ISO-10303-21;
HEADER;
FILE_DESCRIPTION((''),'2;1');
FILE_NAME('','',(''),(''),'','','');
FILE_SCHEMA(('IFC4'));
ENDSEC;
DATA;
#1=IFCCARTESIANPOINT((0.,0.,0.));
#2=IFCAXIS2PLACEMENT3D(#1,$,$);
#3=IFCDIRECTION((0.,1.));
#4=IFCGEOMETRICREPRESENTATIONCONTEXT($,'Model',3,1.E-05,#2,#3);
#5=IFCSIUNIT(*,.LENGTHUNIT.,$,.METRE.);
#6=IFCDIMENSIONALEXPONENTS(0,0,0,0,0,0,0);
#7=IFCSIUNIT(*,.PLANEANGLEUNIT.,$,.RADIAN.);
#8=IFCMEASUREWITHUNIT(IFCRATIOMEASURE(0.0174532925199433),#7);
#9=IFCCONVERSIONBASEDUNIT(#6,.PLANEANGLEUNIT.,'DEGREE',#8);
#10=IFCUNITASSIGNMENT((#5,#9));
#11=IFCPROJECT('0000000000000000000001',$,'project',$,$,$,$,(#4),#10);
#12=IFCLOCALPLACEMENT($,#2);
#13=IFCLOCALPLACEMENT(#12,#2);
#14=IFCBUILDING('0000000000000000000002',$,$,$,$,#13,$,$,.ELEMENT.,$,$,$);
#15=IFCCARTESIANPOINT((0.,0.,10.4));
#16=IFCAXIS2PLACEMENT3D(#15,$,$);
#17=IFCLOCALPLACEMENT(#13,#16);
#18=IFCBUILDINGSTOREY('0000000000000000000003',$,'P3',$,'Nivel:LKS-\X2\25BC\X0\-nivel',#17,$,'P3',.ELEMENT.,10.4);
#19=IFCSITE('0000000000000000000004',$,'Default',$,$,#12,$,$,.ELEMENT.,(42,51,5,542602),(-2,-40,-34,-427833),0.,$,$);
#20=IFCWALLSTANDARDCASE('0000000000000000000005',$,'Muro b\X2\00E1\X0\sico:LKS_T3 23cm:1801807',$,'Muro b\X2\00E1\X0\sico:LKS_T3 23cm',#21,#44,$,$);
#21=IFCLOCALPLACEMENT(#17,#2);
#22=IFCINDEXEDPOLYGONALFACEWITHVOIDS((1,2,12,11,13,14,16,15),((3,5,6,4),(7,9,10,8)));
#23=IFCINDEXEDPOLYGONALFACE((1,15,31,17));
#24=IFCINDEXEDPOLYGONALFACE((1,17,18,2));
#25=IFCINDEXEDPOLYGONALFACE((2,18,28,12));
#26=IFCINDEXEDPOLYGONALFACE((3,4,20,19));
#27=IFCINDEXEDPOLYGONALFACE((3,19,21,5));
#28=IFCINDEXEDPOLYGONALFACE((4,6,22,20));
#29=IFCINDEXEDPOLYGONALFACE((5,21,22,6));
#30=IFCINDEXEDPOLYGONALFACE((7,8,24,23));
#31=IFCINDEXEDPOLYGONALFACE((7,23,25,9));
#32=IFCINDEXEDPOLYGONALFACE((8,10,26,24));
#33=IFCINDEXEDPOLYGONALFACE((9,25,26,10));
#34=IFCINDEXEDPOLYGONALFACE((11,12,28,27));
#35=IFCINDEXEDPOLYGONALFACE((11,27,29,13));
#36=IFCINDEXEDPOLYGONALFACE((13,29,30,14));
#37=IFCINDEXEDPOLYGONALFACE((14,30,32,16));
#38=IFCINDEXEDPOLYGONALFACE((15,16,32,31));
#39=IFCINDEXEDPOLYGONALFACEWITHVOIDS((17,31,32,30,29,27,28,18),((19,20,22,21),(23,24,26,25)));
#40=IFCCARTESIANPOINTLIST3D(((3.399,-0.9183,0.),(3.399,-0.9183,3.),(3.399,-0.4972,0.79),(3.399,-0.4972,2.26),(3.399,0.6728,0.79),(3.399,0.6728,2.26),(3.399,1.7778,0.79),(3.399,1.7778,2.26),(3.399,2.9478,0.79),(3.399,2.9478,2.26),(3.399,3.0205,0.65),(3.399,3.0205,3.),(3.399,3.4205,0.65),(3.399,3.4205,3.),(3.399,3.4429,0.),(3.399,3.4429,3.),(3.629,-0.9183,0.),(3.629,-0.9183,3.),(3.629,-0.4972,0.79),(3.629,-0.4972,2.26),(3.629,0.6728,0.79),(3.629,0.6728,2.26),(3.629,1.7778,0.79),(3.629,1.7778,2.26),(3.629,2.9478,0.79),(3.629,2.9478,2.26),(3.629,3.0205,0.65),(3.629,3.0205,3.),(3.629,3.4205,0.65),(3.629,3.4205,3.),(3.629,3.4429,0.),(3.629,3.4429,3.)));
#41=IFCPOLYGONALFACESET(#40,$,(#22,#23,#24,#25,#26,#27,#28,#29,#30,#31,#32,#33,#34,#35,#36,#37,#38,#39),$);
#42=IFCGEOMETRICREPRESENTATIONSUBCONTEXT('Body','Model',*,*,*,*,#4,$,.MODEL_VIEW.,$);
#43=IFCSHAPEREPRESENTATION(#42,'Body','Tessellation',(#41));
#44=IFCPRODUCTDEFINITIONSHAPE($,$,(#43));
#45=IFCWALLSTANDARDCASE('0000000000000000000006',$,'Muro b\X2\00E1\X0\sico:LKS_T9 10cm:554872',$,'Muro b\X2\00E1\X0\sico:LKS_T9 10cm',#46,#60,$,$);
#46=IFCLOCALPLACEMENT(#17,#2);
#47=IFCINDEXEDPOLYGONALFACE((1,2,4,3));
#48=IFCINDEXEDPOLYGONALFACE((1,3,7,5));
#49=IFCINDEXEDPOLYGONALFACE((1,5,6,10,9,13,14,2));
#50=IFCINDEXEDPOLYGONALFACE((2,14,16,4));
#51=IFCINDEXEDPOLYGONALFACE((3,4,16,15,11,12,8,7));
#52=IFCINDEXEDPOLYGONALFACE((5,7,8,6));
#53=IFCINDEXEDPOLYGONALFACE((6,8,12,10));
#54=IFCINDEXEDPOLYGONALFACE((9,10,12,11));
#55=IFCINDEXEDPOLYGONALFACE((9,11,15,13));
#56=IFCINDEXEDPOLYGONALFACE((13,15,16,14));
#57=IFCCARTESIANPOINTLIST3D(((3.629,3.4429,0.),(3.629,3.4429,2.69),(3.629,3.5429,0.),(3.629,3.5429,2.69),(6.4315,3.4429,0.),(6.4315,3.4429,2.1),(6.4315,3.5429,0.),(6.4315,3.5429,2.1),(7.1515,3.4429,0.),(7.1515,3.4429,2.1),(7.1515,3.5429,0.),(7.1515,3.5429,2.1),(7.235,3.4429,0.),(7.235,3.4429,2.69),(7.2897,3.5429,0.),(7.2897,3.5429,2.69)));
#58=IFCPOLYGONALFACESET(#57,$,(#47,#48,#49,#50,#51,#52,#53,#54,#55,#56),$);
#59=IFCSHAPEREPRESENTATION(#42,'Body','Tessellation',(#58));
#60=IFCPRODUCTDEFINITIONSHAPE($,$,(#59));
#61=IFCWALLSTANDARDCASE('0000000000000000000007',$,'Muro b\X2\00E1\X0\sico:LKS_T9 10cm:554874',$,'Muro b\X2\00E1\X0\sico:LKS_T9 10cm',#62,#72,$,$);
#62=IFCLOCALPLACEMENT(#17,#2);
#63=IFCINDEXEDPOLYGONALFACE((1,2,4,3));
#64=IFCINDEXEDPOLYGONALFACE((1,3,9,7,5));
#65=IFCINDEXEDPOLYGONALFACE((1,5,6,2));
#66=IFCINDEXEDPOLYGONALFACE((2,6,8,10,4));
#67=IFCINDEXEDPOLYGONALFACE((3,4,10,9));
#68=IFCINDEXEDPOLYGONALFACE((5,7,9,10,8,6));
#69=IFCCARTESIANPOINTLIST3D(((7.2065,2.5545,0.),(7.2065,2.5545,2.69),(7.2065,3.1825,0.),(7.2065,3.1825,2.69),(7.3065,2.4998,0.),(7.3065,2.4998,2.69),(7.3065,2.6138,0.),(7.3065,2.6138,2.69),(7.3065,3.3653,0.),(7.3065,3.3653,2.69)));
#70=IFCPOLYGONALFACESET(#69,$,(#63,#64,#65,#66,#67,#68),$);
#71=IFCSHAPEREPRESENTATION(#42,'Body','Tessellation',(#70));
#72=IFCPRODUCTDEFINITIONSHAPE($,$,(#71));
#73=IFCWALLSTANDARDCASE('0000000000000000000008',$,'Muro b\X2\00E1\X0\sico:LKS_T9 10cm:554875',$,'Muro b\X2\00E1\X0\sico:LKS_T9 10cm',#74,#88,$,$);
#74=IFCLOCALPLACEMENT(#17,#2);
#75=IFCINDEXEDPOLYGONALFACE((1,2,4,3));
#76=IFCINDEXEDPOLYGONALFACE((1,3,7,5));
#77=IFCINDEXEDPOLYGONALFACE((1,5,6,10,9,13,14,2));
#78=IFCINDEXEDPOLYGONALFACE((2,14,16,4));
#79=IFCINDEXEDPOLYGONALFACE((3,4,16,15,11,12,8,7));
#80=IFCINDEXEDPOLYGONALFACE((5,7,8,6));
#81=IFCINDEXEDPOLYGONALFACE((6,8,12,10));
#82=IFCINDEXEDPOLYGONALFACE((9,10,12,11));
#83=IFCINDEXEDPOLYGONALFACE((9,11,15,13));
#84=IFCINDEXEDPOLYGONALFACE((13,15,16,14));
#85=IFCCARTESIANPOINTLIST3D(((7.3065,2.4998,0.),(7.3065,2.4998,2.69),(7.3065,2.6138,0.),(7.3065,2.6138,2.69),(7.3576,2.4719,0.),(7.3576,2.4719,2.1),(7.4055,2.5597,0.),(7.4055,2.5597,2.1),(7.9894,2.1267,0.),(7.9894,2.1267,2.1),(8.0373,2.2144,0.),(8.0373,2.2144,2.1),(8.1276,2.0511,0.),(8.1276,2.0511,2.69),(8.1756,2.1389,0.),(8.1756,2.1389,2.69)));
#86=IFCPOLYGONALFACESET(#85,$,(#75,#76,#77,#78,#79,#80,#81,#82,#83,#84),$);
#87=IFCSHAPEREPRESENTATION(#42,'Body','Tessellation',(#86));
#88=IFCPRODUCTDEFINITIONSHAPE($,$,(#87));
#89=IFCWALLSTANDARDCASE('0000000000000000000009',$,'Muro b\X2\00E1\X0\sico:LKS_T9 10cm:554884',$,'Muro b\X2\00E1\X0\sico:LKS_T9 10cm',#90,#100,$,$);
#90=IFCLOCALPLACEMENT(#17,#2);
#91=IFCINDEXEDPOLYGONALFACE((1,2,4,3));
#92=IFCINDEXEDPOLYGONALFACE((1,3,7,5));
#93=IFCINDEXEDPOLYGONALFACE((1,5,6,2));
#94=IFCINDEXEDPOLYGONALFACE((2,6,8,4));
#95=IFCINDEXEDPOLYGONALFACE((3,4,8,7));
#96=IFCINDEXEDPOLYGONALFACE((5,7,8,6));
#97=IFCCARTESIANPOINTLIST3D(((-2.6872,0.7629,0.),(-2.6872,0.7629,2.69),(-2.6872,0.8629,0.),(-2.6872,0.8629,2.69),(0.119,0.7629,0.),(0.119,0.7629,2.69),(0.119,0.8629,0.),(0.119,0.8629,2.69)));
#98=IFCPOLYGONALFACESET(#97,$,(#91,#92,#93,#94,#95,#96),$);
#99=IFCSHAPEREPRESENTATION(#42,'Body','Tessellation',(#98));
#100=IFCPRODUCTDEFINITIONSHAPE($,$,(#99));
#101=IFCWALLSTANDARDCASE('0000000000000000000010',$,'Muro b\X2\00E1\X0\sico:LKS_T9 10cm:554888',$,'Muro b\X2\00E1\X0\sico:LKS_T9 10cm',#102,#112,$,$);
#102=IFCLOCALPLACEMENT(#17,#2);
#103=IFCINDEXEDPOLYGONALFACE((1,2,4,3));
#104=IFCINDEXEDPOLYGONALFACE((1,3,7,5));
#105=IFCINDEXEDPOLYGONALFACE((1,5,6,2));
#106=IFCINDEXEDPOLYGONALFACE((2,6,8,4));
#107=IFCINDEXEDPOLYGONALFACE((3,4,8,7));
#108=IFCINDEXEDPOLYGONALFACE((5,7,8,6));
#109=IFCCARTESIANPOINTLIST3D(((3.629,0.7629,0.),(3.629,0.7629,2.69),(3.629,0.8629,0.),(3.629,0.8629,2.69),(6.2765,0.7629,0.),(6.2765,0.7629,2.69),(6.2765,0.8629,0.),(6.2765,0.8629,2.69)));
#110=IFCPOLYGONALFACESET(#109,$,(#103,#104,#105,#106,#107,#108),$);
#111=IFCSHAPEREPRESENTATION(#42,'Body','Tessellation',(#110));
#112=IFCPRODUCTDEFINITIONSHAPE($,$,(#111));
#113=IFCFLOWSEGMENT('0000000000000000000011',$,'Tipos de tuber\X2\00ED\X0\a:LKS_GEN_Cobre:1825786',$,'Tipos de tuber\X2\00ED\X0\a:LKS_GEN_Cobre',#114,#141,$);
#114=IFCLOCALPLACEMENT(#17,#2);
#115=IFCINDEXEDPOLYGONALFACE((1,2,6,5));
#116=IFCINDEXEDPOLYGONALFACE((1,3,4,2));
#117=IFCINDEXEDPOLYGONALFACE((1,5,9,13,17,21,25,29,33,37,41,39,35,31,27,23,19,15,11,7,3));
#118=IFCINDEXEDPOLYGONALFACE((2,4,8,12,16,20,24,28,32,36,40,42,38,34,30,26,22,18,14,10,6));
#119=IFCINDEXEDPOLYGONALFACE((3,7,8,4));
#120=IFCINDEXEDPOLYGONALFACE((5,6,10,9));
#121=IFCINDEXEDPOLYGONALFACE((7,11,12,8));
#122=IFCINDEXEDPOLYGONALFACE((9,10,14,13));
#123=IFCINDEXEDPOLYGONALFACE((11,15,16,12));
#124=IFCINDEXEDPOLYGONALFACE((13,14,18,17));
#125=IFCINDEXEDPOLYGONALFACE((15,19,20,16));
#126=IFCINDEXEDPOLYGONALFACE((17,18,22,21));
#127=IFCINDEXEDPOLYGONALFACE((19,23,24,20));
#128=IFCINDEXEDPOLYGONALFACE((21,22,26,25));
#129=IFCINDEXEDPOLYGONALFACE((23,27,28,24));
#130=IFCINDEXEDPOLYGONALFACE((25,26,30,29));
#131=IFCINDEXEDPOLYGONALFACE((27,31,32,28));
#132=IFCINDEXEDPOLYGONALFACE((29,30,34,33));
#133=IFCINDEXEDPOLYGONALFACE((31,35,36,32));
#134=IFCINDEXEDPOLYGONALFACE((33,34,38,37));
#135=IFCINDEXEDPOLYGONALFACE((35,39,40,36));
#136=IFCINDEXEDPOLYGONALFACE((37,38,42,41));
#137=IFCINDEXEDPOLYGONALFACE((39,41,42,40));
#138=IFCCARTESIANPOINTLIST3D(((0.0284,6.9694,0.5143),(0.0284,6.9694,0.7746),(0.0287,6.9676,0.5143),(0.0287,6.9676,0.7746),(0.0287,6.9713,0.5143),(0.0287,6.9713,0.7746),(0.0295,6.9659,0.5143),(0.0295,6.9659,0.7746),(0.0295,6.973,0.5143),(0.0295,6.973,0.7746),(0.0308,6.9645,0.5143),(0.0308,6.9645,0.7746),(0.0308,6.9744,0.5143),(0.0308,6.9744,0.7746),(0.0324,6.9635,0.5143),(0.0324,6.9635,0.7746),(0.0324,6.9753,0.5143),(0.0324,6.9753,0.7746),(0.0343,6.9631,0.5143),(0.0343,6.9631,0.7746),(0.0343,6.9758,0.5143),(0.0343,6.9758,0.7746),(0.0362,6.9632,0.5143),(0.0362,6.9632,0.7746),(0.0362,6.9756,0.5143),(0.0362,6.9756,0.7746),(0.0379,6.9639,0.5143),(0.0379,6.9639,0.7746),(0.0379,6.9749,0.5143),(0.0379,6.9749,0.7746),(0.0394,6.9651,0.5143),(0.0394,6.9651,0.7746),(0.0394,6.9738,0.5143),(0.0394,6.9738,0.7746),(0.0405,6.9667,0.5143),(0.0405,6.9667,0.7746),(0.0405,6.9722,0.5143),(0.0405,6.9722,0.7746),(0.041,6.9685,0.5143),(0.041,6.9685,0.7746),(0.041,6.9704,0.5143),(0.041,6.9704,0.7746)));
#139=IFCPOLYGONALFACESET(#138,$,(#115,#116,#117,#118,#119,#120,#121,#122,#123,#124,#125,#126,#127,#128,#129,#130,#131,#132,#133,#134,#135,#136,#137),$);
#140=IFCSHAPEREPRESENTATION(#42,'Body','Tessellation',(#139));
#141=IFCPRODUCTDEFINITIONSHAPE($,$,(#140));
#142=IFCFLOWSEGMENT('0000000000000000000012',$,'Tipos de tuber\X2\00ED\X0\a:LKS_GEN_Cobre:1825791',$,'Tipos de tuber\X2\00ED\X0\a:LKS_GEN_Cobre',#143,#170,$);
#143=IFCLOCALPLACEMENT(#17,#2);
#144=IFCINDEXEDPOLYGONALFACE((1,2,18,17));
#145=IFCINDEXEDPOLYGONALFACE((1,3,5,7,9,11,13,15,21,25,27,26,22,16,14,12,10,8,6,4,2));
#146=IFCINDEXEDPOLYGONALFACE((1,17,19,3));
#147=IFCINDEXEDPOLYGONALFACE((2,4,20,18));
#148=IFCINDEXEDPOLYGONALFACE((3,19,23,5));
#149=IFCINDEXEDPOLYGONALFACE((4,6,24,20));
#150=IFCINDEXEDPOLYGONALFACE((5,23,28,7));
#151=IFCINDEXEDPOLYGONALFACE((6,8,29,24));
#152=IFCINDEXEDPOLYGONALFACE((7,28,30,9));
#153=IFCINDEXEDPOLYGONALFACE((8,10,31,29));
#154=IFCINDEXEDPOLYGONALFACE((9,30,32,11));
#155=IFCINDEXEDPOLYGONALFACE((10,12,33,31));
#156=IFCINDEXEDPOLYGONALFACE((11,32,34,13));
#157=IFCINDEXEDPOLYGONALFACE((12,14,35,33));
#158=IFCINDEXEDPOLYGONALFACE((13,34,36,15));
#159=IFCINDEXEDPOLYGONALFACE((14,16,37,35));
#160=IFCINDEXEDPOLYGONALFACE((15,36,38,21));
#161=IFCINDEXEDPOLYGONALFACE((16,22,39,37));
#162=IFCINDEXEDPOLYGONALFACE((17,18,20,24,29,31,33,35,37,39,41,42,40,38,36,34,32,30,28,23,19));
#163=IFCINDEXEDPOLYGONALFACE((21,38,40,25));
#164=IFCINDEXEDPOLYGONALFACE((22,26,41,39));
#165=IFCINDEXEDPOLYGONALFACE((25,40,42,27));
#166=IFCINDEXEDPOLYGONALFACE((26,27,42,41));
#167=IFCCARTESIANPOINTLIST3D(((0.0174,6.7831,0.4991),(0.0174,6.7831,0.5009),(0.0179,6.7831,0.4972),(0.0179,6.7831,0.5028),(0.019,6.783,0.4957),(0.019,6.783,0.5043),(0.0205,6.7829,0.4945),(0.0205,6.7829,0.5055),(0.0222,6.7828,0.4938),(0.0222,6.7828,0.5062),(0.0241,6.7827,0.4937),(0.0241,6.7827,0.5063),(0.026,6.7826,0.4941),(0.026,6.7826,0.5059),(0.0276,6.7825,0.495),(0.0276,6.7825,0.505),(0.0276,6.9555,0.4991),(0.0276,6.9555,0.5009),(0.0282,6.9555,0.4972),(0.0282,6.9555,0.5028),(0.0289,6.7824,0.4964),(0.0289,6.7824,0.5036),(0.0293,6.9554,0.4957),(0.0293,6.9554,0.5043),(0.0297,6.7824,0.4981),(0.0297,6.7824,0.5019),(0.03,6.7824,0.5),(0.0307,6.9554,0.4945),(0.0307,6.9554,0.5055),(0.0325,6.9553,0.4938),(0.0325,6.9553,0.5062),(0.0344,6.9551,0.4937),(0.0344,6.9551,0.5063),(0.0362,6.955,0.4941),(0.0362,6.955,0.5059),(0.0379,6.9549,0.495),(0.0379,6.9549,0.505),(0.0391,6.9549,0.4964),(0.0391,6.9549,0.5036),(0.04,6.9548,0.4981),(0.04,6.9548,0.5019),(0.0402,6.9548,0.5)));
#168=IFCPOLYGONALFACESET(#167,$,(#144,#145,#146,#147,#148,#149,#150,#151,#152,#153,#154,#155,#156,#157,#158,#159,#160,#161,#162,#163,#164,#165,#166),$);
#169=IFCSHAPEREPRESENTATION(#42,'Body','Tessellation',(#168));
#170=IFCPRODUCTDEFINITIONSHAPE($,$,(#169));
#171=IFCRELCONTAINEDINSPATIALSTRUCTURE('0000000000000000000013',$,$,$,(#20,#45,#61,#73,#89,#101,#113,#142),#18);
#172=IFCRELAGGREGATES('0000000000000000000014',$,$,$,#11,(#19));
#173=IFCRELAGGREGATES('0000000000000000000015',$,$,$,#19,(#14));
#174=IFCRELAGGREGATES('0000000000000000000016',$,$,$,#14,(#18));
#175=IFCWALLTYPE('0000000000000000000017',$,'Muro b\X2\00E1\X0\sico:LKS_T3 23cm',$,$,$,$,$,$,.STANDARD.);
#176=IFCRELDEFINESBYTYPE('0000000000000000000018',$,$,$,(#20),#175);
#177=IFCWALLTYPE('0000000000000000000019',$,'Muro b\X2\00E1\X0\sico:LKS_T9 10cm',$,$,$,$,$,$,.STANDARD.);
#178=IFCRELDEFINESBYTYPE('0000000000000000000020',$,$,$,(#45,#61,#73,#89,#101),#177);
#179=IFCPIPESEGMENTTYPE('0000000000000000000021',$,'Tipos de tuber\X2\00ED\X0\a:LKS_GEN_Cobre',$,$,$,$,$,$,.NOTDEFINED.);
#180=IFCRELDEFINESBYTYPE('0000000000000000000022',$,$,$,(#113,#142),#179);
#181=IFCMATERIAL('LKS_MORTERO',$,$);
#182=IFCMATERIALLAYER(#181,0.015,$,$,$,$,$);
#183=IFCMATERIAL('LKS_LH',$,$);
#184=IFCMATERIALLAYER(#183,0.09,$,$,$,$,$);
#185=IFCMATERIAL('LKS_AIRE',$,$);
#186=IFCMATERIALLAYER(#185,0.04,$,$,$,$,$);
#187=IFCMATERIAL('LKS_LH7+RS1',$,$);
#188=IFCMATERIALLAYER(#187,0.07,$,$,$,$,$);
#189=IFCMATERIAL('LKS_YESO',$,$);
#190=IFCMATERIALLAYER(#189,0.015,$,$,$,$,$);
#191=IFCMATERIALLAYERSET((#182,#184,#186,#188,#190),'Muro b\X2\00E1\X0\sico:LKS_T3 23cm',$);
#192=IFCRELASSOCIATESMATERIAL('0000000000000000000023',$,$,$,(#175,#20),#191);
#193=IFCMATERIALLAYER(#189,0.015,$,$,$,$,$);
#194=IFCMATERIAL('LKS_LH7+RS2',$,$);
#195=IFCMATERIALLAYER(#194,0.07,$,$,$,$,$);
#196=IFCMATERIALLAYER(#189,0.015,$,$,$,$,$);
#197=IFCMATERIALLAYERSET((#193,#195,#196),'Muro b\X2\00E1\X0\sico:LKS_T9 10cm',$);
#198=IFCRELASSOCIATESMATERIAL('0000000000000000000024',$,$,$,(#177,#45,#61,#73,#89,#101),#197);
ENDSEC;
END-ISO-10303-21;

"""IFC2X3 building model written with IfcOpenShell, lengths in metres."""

from ifc_helpers import new_model, entity, si_unit, converted_unit, direction, frame, frame_2d, origin, place, context, subcontext, project, spatial, polyline, rectangle, circle, outline, extrude, clip, bounded_halfspace, material, layer, layer_set, layer_usage, type_object, element, save


model = new_model("IFC2X3")

# Units and contexts
model_context = context("Model", 3, precision=1e-05, world=origin(), true_north=direction((0.0, 1.0)))
body_context = subcontext(model_context, "Body", "Model", "MODEL_VIEW")
ifc_project = project(units=[si_unit("LENGTHUNIT", "METRE"), converted_unit("PLANEANGLEUNIT", "DEGREE", entity("IfcRatioMeasure", 0.0174532925199433), si_unit("PLANEANGLEUNIT", "RADIAN"), dimensions=[0, 0, 0, 0, 0, 0, 0])], contexts=[model_context])

# Site, building, storey
site_placement = place(None, origin())
site = spatial("IfcSite", under=ifc_project, at=site_placement, Name="Default", CompositionType="ELEMENT", RefLatitude=(42, 51, 5, 542602), RefLongitude=(-2, -40, -34, -427833), RefElevation=0.0)
building_placement = place(site_placement, origin())
building = spatial("IfcBuilding", under=site, at=building_placement, CompositionType="ELEMENT")
storey_placement = place(building_placement, frame((0.0, 0.0, 10.4)))
storey = spatial("IfcBuildingStorey", under=building, at=storey_placement, Name="P3", ObjectType="Nivel:LKS-▼-nivel", LongName="P3", CompositionType="ELEMENT", Elevation=10.4)

# Shared definitions
ifc_material_1 = material(Name="LKS_MORTERO")

# Wall, openings
ifc_layer_1 = layer(ifc_material_1, 0.015)
ifc_material_2 = material(Name="LKS_LH")
ifc_layer_2 = layer(ifc_material_2, 0.09)
ifc_material_3 = material(Name="LKS_AIRE")
ifc_layer_3 = layer(ifc_material_3, 0.04)
ifc_material_4 = material(Name="LKS_LH7+RS1")
ifc_layer_4 = layer(ifc_material_4, 0.07)
ifc_material_5 = material(Name="LKS_YESO")
ifc_layer_5 = layer(ifc_material_5, 0.015)
ifc_layer_set_1 = layer_set([ifc_layer_1, ifc_layer_2, ifc_layer_3, ifc_layer_4, ifc_layer_5], Name="Muro básico:LKS_T3 23cm")
ifc_layer_usage_1 = layer_usage(ifc_layer_set_1, "AXIS2", "POSITIVE", -0.115)
wall_type_1 = type_object("IfcWallType", Name="Muro básico:LKS_T3 23cm", PredefinedType="STANDARD", material=ifc_layer_set_1)
wall_1_placement = place(storey_placement, frame((3.514, 3.4429, 0.0), z_axis=(0.0, 0.0, 1.0), x_axis=(0.0, -1.0, 0.0)))
wall_1 = element("IfcWallStandardCase", 1, at=wall_1_placement, inside=storey, type_object=wall_type_1, material=ifc_layer_usage_1, Name="Muro básico:LKS_T3 23cm:1801807", ObjectType="Muro básico:LKS_T3 23cm", context=body_context, shape_type="Clipping", body=[
    clip(extrude(rectangle(XDim=4.3611, YDim=0.23, at=frame_2d((2.1806, 0.0), x_axis=(-1.0, 0.0))), origin(), (0.0, 0.0, 1.0), 3.0), bounded_halfspace(frame((0.4224, -0.115, 0.65), z_axis=(0.0, 0.0, -1.0), x_axis=(0.0, -1.0, 0.0)), True, frame((0.4224, -0.115, 0.65), z_axis=(0.0, 0.0, -1.0), x_axis=(0.0, -1.0, 0.0)), polyline([(0.0, 0.0), (0.0, 0.4), (-0.23, 0.4), (-0.23, 0.0), (0.0, 0.0)]))),
])
opening_1_placement = place(wall_1_placement, frame((3.9401, 0.115, 0.79)))
element("IfcOpeningElement", 2, at=opening_1_placement, cuts=wall_1, ObjectType="Opening", context=body_context, shape_type="SweptSolid", body=[
    extrude(rectangle(XDim=1.47, YDim=1.17, at=frame_2d((0.735, 0.585), x_axis=(1.0, 0.0))), frame((0.0, 0.0, 0.0), z_axis=(0.0, -1.0, 0.0), x_axis=(0.0, 0.0, 1.0)), (0.0, 0.0, 1.0), 0.23),
])
opening_2_placement = place(wall_1_placement, frame((1.6651, 0.115, 0.79)))
element("IfcOpeningElement", 3, at=opening_2_placement, cuts=wall_1, ObjectType="Opening", context=body_context, shape_type="SweptSolid", body=[
    extrude(rectangle(XDim=1.47, YDim=1.17, at=frame_2d((0.735, 0.585), x_axis=(1.0, 0.0))), frame((0.0, 0.0, 0.0), z_axis=(0.0, -1.0, 0.0), x_axis=(0.0, 0.0, 1.0)), (0.0, 0.0, 1.0), 0.23),
])

# Wall, opening
ifc_layer_6 = layer(ifc_material_5, 0.015)
ifc_material_6 = material(Name="LKS_LH7+RS2")
ifc_layer_7 = layer(ifc_material_6, 0.07)
ifc_layer_8 = layer(ifc_material_5, 0.015)
ifc_layer_set_2 = layer_set([ifc_layer_6, ifc_layer_7, ifc_layer_8], Name="Muro básico:LKS_T9 10cm")
ifc_layer_usage_2 = layer_usage(ifc_layer_set_2, "AXIS2", "NEGATIVE", 0.05)
wall_type_2 = type_object("IfcWallType", Name="Muro básico:LKS_T9 10cm", PredefinedType="STANDARD", material=ifc_layer_set_2)
wall_2_placement = place(storey_placement, frame((7.2897, 3.4929, 0.0), z_axis=(0.0, 0.0, 1.0), x_axis=(-1.0, 0.0, 0.0)))
wall_2 = element("IfcWallStandardCase", 4, at=wall_2_placement, inside=storey, type_object=wall_type_2, material=ifc_layer_usage_2, Name="Muro básico:LKS_T9 10cm:554872", ObjectType="Muro básico:LKS_T9 10cm", context=body_context, shape_type="SweptSolid", body=[
    extrude(outline(polyline([(0.0, -0.05), (3.6528, -0.05), (3.6608, -0.05), (3.6608, 0.05), (1.0132, 0.05), (0.9132, 0.05), (0.0547, 0.05), (0.0, -0.05)])), origin(), (0.0, 0.0, 1.0), 2.69),
])
opening_3_placement = place(wall_2_placement, frame((0.8582, 0.05, 0.0)))
element("IfcOpeningElement", 5, at=opening_3_placement, cuts=wall_2, ObjectType="Opening", context=body_context, shape_type="SweptSolid", body=[
    extrude(rectangle(XDim=2.1, YDim=0.72, at=frame_2d((1.05, 0.36), x_axis=(1.0, 0.0))), frame((0.0, 0.0, 0.0), z_axis=(0.0, -1.0, 0.0), x_axis=(0.0, 0.0, 1.0)), (0.0, 0.0, 1.0), 0.1),
])

# Wall
ifc_layer_usage_3 = layer_usage(ifc_layer_set_2, "AXIS2", "NEGATIVE", 0.05)
wall_3_placement = place(storey_placement, frame((7.2565, 3.3653, 0.0), z_axis=(0.0, 0.0, 1.0), x_axis=(0.0, -1.0, 0.0)))
element("IfcWallStandardCase", 6, at=wall_3_placement, inside=storey, type_object=wall_type_2, material=ifc_layer_usage_3, Name="Muro básico:LKS_T9 10cm:554874", ObjectType="Muro básico:LKS_T9 10cm", context=body_context, shape_type="SweptSolid", body=[
    extrude(outline(polyline([(0.8108, -0.05), (0.8655, 0.05), (0.7515, 0.05), (0.0, 0.05), (0.1828, -0.05), (0.8108, -0.05)])), origin(), (0.0, 0.0, 1.0), 2.69),
])

# Wall, opening
ifc_layer_usage_4 = layer_usage(ifc_layer_set_2, "AXIS2", "NEGATIVE", 0.05)
wall_4_placement = place(storey_placement, frame((7.2826, 2.5699, 0.0), z_axis=(0.0, 0.0, 1.0), x_axis=(0.877509, -0.479561, 0.0)))
wall_4 = element("IfcWallStandardCase", 7, at=wall_4_placement, inside=storey, type_object=wall_type_2, material=ifc_layer_usage_4, Name="Muro básico:LKS_T9 10cm:554875", ObjectType="Muro básico:LKS_T9 10cm", context=body_context, shape_type="SweptSolid", body=[
    extrude(outline(polyline([(0.0547, -0.05), (0.9903, -0.05), (0.9903, 0.05), (0.0, 0.05), (0.0547, -0.05)])), origin(), (0.0, 0.0, 1.0), 2.69),
])
opening_4_placement = place(wall_4_placement, frame((0.1128, -0.05, 0.0)))
element("IfcOpeningElement", 8, at=opening_4_placement, cuts=wall_4, ObjectType="Opening", context=body_context, shape_type="SweptSolid", body=[
    extrude(rectangle(XDim=2.1, YDim=0.72, at=frame_2d((1.05, 0.36), x_axis=(1.0, 0.0))), frame((0.0, 0.0, 0.0), z_axis=(0.0, 1.0, 0.0), x_axis=(0.0, 0.0, 1.0)), (0.0, 0.0, 1.0), 0.1),
])

# Walls
ifc_layer_usage_5 = layer_usage(ifc_layer_set_2, "AXIS2", "NEGATIVE", 0.05)
wall_5_placement = place(storey_placement, frame((0.119, 0.8129, 0.0), z_axis=(0.0, 0.0, 1.0), x_axis=(-1.0, 0.0, 0.0)))
element("IfcWallStandardCase", 9, at=wall_5_placement, inside=storey, type_object=wall_type_2, material=ifc_layer_usage_5, Name="Muro básico:LKS_T9 10cm:554884", ObjectType="Muro básico:LKS_T9 10cm", context=body_context, shape_type="SweptSolid", body=[
    extrude(rectangle(XDim=2.8061, YDim=0.1, at=frame_2d((1.4031, 0.0), x_axis=(-1.0, 0.0))), origin(), (0.0, 0.0, 1.0), 2.69),
])
ifc_layer_usage_6 = layer_usage(ifc_layer_set_2, "AXIS2", "NEGATIVE", 0.05)
wall_6_placement = place(storey_placement, frame((6.2765, 0.8129, 0.0), z_axis=(0.0, 0.0, 1.0), x_axis=(-1.0, 0.0, 0.0)))
element("IfcWallStandardCase", 10, at=wall_6_placement, inside=storey, type_object=wall_type_2, material=ifc_layer_usage_6, Name="Muro básico:LKS_T9 10cm:554888", ObjectType="Muro básico:LKS_T9 10cm", context=body_context, shape_type="SweptSolid", body=[
    extrude(rectangle(XDim=2.6476, YDim=0.1, at=frame_2d((1.3238, 0.0), x_axis=(-1.0, 0.0))), origin(), (0.0, 0.0, 1.0), 2.69),
])

# Flow segments
pipe_segment_type = type_object("IfcPipeSegmentType", Name="Tipos de tubería:LKS_GEN_Cobre", PredefinedType="NOTDEFINED")
flow_segment_1_placement = place(storey_placement, origin())
element("IfcFlowSegment", 11, at=flow_segment_1_placement, inside=storey, type_object=pipe_segment_type, Name="Tipos de tubería:LKS_GEN_Cobre:1825786", ObjectType="Tipos de tubería:LKS_GEN_Cobre", context=body_context, shape_type="SweptSolid", body=[
    extrude(circle(Radius=0.0063, at=frame_2d((0.0, 0.0), x_axis=(1.0, 0.0))), frame((0.0348, 6.9694, 0.5143), z_axis=(0.0, 0.0, 1.0), x_axis=(-1.0, 0.0, 0.0)), (0.0, 0.0, 1.0), 0.2603),
])
flow_segment_2_placement = place(storey_placement, origin())
element("IfcFlowSegment", 12, at=flow_segment_2_placement, inside=storey, type_object=pipe_segment_type, Name="Tipos de tubería:LKS_GEN_Cobre:1825791", ObjectType="Tipos de tubería:LKS_GEN_Cobre", context=body_context, shape_type="SweptSolid", body=[
    extrude(circle(Radius=0.0063, at=frame_2d((0.0, 0.0), x_axis=(1.0, 0.0))), frame((0.0236, 6.7827, 0.5), z_axis=(0.059398, 0.998234, 0.0), x_axis=(0.998234, -0.059398, 0.0)), (0.0, 0.0, 1.0), 0.1727),
])

save(model, "model.ifc")
